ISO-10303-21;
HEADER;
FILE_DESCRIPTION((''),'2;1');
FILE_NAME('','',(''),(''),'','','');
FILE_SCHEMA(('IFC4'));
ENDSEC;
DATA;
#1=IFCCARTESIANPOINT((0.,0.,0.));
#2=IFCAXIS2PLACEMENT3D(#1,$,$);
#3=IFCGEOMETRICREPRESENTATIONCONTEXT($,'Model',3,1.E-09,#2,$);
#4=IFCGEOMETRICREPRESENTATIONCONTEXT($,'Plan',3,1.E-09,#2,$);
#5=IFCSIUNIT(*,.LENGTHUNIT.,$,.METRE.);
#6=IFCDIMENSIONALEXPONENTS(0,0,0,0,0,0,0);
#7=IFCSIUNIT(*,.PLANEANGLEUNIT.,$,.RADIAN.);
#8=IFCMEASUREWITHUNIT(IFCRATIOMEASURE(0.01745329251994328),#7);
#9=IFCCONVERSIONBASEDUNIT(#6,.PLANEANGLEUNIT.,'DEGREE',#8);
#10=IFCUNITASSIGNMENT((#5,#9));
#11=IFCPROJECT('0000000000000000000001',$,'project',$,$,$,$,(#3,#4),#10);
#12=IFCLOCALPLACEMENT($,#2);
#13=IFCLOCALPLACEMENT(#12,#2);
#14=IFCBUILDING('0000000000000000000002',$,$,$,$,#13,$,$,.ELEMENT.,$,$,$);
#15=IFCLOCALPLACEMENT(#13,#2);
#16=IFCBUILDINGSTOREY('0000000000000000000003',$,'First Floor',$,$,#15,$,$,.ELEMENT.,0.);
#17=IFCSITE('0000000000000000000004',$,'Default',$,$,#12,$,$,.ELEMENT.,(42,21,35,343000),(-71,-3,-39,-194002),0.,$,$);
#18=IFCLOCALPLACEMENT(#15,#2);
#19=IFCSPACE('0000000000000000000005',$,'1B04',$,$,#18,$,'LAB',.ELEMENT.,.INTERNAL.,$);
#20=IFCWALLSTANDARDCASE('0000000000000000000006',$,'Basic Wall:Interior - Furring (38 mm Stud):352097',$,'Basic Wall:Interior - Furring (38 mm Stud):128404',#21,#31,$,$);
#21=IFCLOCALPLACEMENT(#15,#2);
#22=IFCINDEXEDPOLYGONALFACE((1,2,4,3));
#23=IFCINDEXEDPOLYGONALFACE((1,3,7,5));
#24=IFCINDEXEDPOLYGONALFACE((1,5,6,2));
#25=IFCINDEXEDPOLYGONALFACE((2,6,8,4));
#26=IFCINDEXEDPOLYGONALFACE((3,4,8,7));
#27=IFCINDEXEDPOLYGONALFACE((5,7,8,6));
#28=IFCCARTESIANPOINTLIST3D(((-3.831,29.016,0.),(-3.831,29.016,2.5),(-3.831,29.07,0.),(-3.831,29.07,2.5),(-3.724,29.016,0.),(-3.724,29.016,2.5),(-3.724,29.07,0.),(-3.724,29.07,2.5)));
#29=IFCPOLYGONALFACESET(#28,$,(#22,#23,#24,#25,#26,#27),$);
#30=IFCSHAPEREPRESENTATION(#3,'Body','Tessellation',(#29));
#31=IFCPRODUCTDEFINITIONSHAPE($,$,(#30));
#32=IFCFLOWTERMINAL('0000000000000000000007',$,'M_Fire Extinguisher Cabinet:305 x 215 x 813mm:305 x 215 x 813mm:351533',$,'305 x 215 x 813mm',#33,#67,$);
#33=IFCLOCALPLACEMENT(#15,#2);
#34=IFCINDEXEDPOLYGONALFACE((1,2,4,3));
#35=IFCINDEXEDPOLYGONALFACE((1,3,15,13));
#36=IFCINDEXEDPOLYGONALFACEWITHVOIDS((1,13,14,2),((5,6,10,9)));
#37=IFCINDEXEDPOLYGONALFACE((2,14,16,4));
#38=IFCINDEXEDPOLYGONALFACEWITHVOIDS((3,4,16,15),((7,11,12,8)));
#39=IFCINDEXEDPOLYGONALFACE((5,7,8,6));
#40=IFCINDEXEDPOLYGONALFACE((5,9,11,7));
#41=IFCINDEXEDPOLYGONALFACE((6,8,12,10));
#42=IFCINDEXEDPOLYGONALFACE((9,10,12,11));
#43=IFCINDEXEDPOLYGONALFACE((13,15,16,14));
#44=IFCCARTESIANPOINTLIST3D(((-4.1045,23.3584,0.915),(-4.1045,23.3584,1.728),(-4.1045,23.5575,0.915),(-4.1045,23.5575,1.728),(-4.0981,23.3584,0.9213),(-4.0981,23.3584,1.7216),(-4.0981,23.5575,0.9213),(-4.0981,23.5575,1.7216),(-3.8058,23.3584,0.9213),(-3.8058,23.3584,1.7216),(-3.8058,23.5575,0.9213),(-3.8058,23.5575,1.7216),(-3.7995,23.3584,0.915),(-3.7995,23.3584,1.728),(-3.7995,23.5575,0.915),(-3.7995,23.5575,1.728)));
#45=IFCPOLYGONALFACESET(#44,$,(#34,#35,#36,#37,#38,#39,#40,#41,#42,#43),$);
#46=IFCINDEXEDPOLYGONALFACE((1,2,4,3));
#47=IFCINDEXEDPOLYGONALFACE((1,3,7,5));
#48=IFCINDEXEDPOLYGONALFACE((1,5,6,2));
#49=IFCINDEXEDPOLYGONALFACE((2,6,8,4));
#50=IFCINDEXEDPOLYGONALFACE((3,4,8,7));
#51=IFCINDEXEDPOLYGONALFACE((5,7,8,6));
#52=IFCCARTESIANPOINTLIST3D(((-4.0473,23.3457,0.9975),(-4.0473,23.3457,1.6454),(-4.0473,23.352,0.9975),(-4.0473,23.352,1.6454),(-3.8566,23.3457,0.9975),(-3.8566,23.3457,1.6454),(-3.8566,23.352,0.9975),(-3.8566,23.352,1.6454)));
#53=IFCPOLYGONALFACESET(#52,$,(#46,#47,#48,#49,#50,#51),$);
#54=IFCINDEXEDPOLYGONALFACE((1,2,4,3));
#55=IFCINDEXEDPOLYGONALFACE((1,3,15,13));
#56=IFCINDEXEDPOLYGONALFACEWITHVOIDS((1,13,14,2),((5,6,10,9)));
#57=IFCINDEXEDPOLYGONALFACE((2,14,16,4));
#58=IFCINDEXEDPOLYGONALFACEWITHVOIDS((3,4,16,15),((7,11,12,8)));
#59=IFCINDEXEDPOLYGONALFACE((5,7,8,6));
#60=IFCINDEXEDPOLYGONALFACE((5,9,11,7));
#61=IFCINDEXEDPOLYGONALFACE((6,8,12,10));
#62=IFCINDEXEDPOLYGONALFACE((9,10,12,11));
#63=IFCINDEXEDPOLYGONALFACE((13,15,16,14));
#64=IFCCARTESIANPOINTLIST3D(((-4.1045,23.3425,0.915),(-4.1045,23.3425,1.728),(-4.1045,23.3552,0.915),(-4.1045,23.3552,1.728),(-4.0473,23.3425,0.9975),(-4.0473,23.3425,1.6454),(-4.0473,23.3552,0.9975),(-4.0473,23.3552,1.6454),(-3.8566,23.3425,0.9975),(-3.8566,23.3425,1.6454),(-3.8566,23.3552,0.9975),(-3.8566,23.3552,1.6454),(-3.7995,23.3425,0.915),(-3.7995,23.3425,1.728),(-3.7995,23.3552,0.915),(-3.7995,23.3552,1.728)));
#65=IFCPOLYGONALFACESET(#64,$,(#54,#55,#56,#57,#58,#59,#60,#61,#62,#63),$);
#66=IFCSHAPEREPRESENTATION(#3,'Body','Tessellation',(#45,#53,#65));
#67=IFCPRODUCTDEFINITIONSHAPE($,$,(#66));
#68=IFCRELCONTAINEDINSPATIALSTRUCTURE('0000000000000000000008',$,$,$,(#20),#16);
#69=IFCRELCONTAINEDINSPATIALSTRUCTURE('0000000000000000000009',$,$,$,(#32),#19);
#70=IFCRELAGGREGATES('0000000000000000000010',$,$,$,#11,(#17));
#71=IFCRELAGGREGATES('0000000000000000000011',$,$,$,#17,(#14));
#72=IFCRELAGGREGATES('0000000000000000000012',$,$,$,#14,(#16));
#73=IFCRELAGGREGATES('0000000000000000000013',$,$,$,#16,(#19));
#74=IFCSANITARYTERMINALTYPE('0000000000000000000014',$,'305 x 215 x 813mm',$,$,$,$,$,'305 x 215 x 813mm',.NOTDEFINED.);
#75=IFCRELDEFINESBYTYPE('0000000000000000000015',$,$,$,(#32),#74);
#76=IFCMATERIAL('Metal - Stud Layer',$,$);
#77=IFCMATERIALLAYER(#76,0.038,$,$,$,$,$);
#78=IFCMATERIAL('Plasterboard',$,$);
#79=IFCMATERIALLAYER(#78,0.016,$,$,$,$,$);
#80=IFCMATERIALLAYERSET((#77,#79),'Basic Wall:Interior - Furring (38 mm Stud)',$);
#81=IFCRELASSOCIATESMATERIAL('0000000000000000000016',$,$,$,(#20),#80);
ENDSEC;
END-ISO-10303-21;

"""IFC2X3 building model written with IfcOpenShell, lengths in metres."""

from ifc_helpers import new_model, entity, si_unit, converted_unit, frame, frame_2d, origin, origin_2d_with_axis, place, context, project, spatial, rectangle, extrude, source, transform, mapped, material, layer, layer_set, layer_usage, type_object, type_shapes, element, save


model = new_model("IFC2X3")

# Units and contexts
model_context = context("Model", 3, precision=1e-09, world=origin())
plan_context = context("Plan", 3, precision=1e-09, world=origin())
ifc_project = project(units=[si_unit("LENGTHUNIT", "METRE"), converted_unit("PLANEANGLEUNIT", "DEGREE", entity("IfcRatioMeasure", 0.01745329251994328), si_unit("PLANEANGLEUNIT", "RADIAN"), dimensions=[0, 0, 0, 0, 0, 0, 0])], contexts=[model_context, plan_context])

# Site, building, storey
site_placement = place(None, origin())
site = spatial("IfcSite", under=ifc_project, at=site_placement, Name="Default", CompositionType="ELEMENT", RefLatitude=(42, 21, 35, 343000), RefLongitude=(-71, -3, -39, -194002), RefElevation=0.0)
building_placement = place(site_placement, origin())
building = spatial("IfcBuilding", under=site, at=building_placement, CompositionType="ELEMENT")
storey_placement = place(building_placement, origin())
storey = spatial("IfcBuildingStorey", under=building, at=storey_placement, Name="First Floor", CompositionType="ELEMENT", Elevation=0.0)

# Shared definitions
ifc_material_1 = material(Name="Plasterboard")
ifc_layer_1 = layer(ifc_material_1, 0.016)
ifc_material_2 = material(Name="Metal - Stud Layer")

# Shared definitions
ifc_layer_2 = layer(ifc_material_2, 0.038)
ifc_layer_set_1 = layer_set([ifc_layer_2, ifc_layer_1], Name="Basic Wall:Interior - Furring (38 mm Stud)")
ifc_layer_usage_1 = layer_usage(ifc_layer_set_1, "AXIS2", "POSITIVE", -0.027)

# Wall
wall_1_placement = place(storey_placement, frame((-3.831, 29.043, 0.0)))
element("IfcWallStandardCase", 1, at=wall_1_placement, inside=storey, material=ifc_layer_usage_1, Name="Basic Wall:Interior - Furring (38 mm Stud):352097", ObjectType="Basic Wall:Interior - Furring (38 mm Stud):128404", context=model_context, shape_type="SweptSolid", body=[
    extrude(rectangle(XDim=0.107, YDim=0.054, at=frame_2d((0.0535, 0.0), x_axis=(-1.0, 0.0))), origin(), (0.0, 0.0, 1.0), 2.5),
])

# Shared definitions
space_placement = place(storey_placement, origin())
space = spatial("IfcSpace", under=storey, at=space_placement, Name="1B04", LongName="LAB", CompositionType="ELEMENT", InteriorOrExteriorSpace="INTERNAL")

# Flow terminal
sanitary_terminal_type = type_object("IfcSanitaryTerminalType", Name="305 x 215 x 813mm", ElementType="305 x 215 x 813mm", PredefinedType="NOTDEFINED")
cartesian_point_1 = entity("IfcCartesianPoint", [-0.1525, -0.4065])
shared_polyline = entity("IfcPolyline", [cartesian_point_1, entity("IfcCartesianPoint", [0.1525, -0.4065]), entity("IfcCartesianPoint", [0.1525, 0.4065]), entity("IfcCartesianPoint", [-0.1525, 0.4065]), cartesian_point_1])
cartesian_point_2 = entity("IfcCartesianPoint", [-0.1462, -0.4001])
cartesian_point_3 = entity("IfcCartesianPoint", [-0.0953, -0.3239])
shared_shape_1 = source(origin(), model_context, "Body", "SweptSolid", [
    entity("IfcExtrudedAreaSolid", entity("IfcArbitraryProfileDefWithVoids", "AREA", None, shared_polyline, [entity("IfcPolyline", [cartesian_point_2, entity("IfcCartesianPoint", [-0.1462, 0.4002]), entity("IfcCartesianPoint", [0.1462, 0.4002]), entity("IfcCartesianPoint", [0.1462, -0.4001]), cartesian_point_2])]), entity("IfcAxis2Placement3D", entity("IfcCartesianPoint", [-0.1096, 0.062, 1.3215]), entity("IfcDirection", [0.0, 1.0, 0.0]), entity("IfcDirection", [1.0, 0.0, 0.0])), entity("IfcDirection", [0.0, 0.0, 1.0]), 0.1991),
    extrude(rectangle(XDim=0.0064, YDim=0.1907, at=origin_2d_with_axis()), frame((-0.1096, 0.2706, 0.9975), z_axis=(0.0, 0.0, 1.0), x_axis=(0.0, -1.0, 0.0)), (0.0, 0.0, 1.0), 0.6479),
    entity("IfcExtrudedAreaSolid", entity("IfcArbitraryProfileDefWithVoids", "AREA", None, shared_polyline, [entity("IfcPolyline", [cartesian_point_3, entity("IfcCartesianPoint", [-0.0953, 0.324]), entity("IfcCartesianPoint", [0.0954, 0.324]), entity("IfcCartesianPoint", [0.0954, -0.3239]), cartesian_point_3])]), entity("IfcAxis2Placement3D", entity("IfcCartesianPoint", [-0.1096, 0.2643, 1.3215]), entity("IfcDirection", [0.0, 1.0, 0.0]), entity("IfcDirection", [1.0, 0.0, 0.0])), entity("IfcDirection", [0.0, 0.0, 1.0]), 0.0127),
])
type_shapes(sanitary_terminal_type, [shared_shape_1])
flow_terminal_placement = place(space_placement, frame((-4.0616, 23.6195, 0.0), z_axis=(0.0, 0.0, 1.0), x_axis=(-1.0, 0.0, 0.0)))
element("IfcFlowTerminal", 2, at=flow_terminal_placement, inside=space, type_object=sanitary_terminal_type, Name="M_Fire Extinguisher Cabinet:305 x 215 x 813mm:305 x 215 x 813mm:351533", ObjectType="305 x 215 x 813mm", context=model_context, shape_type="MappedRepresentation", body=[
    mapped(shared_shape_1, transform((0.0, 0.0, 0.0), scale=1.0)),
])

save(model, "model.ifc")
